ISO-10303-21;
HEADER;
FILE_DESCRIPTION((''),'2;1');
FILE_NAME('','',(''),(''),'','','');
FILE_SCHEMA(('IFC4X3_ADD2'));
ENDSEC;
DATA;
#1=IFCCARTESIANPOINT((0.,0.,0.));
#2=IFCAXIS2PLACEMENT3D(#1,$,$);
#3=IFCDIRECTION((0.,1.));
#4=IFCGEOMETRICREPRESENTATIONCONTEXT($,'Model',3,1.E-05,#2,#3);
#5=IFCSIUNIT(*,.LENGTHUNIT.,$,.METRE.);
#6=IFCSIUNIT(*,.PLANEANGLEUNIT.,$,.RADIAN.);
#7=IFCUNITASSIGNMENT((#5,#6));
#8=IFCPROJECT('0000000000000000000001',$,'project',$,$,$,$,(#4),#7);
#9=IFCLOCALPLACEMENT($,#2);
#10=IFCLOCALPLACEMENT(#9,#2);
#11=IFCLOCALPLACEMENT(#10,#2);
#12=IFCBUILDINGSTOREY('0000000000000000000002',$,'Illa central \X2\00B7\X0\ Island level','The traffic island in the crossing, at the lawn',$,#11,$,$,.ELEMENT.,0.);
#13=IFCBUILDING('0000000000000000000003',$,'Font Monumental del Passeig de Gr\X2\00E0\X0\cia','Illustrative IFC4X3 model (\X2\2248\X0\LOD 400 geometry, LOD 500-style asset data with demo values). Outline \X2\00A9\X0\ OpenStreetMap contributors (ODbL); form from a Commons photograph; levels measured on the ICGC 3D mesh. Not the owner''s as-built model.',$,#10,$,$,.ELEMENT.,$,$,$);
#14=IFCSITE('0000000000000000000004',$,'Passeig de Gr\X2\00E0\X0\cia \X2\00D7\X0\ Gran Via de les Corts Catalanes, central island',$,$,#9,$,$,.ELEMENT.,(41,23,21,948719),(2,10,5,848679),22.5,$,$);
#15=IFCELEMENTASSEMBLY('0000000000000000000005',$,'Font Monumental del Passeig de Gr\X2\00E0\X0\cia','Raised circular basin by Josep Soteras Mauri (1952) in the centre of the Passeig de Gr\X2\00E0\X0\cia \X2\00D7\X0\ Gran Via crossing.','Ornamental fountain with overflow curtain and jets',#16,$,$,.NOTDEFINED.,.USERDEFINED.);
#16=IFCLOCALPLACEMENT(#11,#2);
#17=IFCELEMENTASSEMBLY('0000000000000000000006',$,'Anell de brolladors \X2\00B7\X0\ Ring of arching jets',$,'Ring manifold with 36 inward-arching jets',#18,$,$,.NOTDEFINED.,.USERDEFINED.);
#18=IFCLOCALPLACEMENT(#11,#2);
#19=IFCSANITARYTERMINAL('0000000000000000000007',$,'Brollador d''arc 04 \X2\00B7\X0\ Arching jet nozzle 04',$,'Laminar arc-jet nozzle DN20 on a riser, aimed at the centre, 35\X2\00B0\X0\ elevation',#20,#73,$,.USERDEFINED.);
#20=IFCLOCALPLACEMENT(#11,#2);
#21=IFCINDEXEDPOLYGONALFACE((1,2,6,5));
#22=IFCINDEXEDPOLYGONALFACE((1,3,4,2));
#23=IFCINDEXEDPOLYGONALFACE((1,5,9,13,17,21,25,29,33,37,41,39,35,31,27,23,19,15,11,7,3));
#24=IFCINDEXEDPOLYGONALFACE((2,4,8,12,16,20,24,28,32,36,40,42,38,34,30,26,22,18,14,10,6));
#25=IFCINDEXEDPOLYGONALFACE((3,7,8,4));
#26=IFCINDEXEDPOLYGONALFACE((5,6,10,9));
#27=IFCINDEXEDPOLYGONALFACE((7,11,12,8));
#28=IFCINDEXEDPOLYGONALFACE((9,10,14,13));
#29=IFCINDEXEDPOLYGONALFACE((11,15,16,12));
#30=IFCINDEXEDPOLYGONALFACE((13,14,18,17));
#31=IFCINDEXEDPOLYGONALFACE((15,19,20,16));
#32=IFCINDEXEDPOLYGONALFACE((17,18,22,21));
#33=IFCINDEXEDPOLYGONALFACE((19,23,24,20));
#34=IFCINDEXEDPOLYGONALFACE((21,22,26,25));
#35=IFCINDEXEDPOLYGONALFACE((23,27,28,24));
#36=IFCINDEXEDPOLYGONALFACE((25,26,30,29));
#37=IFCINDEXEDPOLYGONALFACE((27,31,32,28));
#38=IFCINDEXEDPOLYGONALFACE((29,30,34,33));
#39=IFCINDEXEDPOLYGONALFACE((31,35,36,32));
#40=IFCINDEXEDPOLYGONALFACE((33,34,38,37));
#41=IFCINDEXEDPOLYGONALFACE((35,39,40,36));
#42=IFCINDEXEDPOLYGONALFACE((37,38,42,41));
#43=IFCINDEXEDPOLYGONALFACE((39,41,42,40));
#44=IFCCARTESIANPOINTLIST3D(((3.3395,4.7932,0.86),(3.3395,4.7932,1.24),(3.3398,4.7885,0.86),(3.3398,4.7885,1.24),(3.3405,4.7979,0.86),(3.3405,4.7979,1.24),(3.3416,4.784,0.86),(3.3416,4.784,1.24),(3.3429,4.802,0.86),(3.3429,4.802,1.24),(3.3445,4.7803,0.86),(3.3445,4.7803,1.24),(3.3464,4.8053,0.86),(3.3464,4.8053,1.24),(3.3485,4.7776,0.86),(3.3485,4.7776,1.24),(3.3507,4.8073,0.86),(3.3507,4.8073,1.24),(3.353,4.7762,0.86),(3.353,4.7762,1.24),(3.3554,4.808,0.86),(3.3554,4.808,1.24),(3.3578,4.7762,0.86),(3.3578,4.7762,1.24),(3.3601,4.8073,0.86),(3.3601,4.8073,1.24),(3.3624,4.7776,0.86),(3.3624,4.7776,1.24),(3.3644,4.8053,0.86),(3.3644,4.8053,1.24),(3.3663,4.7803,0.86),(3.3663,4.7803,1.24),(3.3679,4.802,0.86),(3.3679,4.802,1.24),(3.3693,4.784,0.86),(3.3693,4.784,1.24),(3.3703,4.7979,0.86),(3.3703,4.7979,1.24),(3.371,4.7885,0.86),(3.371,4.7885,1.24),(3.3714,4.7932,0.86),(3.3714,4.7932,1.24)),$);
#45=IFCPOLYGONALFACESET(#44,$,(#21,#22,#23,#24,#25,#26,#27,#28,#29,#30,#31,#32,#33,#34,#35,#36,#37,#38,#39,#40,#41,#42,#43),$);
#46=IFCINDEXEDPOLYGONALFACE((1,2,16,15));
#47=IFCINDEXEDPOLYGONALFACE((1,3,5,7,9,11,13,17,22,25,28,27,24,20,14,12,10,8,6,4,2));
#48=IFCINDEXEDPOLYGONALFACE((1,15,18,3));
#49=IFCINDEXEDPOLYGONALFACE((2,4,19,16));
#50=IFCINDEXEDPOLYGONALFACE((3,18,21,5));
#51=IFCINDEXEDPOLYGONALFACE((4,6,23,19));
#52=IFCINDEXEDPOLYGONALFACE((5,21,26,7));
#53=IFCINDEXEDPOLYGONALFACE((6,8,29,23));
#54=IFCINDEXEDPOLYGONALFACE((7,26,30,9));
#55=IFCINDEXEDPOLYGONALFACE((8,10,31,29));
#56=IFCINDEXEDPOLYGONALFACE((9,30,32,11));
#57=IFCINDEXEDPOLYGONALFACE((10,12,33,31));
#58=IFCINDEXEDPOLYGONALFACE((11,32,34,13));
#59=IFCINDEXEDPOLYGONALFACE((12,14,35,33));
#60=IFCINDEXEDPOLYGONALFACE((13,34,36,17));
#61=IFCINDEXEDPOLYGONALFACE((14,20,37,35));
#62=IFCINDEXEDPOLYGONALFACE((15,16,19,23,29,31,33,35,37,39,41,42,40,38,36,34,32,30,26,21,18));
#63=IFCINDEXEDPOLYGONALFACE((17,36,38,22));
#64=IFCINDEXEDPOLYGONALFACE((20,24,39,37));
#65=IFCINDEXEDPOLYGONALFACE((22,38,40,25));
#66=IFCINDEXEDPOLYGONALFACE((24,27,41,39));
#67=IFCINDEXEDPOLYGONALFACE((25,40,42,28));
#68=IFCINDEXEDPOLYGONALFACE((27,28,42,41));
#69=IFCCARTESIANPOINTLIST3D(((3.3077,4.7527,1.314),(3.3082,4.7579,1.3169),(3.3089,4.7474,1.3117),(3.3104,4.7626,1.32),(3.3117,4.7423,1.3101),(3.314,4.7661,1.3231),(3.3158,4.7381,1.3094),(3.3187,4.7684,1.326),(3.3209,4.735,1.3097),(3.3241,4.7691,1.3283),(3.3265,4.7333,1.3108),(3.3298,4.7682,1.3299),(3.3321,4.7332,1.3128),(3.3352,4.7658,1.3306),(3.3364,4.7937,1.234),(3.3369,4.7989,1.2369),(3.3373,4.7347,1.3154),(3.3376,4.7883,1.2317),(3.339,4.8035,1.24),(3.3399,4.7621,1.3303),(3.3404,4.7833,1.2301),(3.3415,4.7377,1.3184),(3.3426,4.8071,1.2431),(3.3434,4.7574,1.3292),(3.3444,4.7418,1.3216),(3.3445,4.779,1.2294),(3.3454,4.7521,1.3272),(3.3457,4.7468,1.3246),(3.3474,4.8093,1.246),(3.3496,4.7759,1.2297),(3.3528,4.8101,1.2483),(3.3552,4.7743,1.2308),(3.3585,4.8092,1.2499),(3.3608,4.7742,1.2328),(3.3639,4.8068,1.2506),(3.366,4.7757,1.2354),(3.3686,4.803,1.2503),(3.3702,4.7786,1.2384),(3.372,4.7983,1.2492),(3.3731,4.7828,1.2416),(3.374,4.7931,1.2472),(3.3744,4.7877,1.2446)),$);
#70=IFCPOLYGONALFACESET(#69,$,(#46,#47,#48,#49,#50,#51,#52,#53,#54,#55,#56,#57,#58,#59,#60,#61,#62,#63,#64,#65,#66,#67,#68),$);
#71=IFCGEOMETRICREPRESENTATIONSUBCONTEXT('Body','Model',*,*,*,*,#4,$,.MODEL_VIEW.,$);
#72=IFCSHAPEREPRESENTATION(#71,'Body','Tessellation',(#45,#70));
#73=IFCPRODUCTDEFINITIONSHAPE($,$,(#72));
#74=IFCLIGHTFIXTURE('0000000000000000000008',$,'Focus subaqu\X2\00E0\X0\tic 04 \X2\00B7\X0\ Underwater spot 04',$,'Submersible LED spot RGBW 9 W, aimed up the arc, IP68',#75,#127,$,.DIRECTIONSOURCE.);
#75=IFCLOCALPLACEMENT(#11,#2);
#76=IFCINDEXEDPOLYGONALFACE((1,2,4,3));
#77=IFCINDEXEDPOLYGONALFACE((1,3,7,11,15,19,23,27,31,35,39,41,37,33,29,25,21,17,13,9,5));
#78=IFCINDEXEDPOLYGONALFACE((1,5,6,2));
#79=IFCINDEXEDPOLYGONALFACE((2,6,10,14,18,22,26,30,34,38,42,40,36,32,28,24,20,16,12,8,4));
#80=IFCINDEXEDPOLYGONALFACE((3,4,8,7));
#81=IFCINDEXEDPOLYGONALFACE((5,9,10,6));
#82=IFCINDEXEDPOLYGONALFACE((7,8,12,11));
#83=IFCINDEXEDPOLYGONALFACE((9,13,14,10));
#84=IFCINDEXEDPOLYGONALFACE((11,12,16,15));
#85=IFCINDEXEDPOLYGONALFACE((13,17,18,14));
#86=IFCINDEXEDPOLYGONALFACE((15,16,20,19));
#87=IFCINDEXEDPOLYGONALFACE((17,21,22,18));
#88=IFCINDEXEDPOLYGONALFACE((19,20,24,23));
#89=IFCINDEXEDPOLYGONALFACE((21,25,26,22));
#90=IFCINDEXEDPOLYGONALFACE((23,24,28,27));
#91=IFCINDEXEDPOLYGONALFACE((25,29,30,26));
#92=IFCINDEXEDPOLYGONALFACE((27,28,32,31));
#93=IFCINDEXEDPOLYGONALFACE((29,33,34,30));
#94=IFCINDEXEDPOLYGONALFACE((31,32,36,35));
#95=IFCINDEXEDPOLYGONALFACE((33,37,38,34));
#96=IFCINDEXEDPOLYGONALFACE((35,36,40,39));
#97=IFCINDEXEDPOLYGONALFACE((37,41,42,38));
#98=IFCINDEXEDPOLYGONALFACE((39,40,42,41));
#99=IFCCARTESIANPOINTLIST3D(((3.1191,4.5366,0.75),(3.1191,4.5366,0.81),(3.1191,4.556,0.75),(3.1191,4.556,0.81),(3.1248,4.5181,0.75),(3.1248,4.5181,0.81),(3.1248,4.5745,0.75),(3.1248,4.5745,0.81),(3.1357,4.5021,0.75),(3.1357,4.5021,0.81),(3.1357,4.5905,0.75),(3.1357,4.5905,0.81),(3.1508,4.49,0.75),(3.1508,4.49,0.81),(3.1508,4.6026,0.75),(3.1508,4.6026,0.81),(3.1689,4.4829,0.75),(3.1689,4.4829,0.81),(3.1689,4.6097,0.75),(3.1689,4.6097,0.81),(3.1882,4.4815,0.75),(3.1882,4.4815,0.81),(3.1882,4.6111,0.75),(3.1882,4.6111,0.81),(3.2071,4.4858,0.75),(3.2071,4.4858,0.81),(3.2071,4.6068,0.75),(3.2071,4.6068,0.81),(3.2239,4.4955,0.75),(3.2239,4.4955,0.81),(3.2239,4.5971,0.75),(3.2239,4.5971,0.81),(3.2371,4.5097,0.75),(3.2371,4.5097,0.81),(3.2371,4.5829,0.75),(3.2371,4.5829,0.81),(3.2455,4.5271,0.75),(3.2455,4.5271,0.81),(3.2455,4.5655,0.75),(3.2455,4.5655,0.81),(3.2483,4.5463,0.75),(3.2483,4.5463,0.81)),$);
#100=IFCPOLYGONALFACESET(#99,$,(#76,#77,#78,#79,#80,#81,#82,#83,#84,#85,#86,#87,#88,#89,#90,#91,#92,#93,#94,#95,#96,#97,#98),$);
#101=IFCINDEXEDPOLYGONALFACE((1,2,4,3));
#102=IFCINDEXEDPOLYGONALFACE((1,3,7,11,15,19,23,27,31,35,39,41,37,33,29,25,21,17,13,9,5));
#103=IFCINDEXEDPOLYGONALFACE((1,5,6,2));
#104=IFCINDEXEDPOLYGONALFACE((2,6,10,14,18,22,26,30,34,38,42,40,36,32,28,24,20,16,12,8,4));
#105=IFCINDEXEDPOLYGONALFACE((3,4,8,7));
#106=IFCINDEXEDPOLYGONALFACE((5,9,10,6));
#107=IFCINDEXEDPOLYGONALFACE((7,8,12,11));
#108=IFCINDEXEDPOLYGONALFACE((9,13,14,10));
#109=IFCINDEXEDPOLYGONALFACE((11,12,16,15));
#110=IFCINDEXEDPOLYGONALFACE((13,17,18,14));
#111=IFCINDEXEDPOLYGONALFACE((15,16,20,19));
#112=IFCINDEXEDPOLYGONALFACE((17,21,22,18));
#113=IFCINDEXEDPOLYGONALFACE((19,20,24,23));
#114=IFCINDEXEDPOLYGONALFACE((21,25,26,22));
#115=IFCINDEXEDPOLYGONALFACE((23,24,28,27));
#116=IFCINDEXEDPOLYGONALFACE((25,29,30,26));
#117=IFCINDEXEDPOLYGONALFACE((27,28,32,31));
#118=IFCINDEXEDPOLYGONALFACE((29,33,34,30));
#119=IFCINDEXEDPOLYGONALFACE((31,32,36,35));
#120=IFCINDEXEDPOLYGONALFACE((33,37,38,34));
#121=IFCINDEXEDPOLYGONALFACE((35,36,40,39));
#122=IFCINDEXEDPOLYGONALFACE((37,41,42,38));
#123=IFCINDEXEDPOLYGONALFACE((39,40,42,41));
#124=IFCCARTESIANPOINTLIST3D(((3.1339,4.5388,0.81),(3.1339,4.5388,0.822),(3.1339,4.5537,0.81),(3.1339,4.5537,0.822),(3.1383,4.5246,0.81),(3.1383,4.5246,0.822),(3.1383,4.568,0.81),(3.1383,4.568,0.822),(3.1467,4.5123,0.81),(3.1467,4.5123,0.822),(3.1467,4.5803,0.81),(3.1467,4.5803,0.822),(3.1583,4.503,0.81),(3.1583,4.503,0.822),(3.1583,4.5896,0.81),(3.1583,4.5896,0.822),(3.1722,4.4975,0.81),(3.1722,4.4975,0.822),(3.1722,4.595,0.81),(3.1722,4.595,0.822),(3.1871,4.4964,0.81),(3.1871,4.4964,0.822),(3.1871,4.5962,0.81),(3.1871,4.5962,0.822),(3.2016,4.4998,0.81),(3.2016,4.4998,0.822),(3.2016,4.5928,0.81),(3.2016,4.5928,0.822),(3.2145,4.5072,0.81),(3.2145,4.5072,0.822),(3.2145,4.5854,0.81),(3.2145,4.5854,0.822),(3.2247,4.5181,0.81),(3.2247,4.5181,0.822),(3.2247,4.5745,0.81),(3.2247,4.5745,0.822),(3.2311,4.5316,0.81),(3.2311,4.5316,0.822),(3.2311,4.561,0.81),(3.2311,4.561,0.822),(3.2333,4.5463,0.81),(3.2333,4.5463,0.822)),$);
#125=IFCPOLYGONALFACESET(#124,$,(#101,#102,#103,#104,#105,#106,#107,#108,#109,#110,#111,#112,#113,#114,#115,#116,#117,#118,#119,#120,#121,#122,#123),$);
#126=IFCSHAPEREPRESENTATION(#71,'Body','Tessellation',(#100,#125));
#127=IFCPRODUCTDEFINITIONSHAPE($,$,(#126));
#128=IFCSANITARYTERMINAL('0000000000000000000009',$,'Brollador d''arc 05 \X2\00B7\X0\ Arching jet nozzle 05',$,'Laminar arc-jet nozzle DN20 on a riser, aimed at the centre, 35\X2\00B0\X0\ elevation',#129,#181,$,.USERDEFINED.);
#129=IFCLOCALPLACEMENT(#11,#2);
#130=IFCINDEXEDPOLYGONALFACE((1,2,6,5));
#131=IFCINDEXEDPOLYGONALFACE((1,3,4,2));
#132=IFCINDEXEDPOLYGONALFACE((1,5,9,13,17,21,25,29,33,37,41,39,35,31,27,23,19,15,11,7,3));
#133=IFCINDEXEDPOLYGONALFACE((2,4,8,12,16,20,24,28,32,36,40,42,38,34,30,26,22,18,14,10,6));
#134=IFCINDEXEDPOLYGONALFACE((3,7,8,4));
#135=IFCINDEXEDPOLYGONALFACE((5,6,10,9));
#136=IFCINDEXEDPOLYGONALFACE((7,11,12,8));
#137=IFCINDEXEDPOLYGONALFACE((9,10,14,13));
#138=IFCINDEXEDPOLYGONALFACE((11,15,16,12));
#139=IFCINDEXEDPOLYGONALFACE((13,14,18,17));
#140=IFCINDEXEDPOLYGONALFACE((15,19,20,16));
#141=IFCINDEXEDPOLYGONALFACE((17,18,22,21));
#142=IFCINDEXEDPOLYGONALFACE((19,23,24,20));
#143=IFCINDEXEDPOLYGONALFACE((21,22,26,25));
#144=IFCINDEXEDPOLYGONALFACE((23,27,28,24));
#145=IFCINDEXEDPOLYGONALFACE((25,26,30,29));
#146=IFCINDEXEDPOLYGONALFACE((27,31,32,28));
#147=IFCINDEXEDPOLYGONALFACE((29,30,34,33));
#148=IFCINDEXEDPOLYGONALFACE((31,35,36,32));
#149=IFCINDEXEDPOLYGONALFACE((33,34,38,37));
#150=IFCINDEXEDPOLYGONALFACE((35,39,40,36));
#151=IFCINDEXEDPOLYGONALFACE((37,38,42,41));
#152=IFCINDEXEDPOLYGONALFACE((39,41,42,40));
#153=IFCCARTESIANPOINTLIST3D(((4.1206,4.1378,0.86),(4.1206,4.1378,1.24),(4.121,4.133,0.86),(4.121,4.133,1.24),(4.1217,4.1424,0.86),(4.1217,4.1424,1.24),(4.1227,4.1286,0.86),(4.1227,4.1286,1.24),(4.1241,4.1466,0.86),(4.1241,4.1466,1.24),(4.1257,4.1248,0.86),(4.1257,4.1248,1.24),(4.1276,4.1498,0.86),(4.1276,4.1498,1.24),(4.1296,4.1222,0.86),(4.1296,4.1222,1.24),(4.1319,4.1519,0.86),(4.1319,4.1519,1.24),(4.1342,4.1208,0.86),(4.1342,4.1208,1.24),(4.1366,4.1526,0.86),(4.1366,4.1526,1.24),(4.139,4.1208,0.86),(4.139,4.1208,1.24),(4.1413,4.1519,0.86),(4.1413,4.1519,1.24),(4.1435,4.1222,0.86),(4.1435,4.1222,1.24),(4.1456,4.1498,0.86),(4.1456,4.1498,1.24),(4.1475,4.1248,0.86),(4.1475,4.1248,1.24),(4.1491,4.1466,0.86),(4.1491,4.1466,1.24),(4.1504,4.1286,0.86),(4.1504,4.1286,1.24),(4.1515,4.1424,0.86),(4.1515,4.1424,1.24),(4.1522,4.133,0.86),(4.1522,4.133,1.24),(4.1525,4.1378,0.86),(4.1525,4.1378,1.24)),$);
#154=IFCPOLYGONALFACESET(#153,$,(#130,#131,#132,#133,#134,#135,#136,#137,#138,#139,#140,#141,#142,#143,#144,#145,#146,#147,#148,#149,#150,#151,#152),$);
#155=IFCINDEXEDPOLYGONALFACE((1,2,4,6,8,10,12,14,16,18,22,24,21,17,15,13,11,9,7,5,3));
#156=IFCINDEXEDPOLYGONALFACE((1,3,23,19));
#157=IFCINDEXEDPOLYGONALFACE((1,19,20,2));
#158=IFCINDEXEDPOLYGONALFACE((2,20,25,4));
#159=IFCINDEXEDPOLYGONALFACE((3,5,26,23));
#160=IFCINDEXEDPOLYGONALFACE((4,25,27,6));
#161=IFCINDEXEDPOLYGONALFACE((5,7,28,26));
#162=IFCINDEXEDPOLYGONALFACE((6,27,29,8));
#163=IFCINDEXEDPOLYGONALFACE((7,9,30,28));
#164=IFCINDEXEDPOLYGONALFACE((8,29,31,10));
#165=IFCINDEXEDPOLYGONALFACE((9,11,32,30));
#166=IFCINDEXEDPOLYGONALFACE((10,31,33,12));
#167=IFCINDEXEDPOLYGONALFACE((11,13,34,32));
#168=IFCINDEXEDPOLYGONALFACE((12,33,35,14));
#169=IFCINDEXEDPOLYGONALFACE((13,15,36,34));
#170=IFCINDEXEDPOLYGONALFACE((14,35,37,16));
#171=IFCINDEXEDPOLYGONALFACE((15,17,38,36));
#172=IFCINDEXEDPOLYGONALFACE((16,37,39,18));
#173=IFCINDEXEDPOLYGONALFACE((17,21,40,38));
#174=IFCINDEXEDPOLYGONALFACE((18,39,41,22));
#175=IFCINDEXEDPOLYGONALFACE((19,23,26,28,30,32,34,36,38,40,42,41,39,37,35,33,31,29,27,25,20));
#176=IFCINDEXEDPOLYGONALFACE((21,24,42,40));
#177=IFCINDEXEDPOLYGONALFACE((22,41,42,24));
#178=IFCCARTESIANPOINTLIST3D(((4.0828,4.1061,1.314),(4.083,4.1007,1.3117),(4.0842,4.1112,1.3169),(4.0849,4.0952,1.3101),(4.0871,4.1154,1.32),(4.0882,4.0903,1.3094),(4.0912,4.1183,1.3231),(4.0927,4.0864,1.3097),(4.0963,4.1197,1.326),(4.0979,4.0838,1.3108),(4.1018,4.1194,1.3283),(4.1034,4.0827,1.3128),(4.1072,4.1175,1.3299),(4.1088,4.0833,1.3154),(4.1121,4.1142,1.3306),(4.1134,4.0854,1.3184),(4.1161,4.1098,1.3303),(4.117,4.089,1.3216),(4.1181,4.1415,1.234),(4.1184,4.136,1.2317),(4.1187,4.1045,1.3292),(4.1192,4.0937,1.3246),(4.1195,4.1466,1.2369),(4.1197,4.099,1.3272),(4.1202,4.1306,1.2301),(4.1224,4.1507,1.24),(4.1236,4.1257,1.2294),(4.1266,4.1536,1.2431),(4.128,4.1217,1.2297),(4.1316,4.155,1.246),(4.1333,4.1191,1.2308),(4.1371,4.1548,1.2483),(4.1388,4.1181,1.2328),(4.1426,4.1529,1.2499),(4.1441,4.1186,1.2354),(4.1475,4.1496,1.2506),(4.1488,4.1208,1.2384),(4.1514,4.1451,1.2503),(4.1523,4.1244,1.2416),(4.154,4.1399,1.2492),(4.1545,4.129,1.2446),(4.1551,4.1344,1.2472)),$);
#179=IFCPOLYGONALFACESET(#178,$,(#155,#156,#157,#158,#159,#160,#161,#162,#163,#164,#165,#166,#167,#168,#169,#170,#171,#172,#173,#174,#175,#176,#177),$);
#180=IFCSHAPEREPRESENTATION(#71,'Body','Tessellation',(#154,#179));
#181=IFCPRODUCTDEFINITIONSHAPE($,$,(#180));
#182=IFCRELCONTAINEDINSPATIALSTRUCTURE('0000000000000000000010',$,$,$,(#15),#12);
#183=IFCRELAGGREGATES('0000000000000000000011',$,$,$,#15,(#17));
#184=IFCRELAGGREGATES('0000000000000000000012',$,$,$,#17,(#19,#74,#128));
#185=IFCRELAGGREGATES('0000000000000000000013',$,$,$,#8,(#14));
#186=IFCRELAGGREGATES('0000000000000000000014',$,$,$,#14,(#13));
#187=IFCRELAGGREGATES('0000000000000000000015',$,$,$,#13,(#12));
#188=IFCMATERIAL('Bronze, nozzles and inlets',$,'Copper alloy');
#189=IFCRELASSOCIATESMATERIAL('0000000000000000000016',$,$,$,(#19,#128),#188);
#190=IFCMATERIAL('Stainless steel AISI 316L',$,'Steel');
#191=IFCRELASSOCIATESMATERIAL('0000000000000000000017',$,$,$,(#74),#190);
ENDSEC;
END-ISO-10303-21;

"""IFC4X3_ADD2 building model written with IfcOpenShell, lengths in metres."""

from ifc_helpers import new_model, si_unit, direction, frame, origin, origin_2d_with_axis, place, context, subcontext, project, spatial, circle, extrude, material, element, aggregate, save


model = new_model("IFC4X3_ADD2")

# Units and contexts
model_context = context("Model", 3, precision=1e-05, world=origin(), true_north=direction((0.0, 1.0)))
body_context = subcontext(model_context, "Body", "Model", "MODEL_VIEW")
ifc_project = project(units=[si_unit("LENGTHUNIT", "METRE"), si_unit("PLANEANGLEUNIT", "RADIAN")], contexts=[model_context])

# Site, building, storey
site_placement = place(None, origin())
site = spatial("IfcSite", under=ifc_project, at=site_placement, Name="Passeig de Gràcia × Gran Via de les Corts Catalanes, central island", CompositionType="ELEMENT", RefLatitude=(41, 23, 21, 948719), RefLongitude=(2, 10, 5, 848679), RefElevation=22.5)
building_placement = place(site_placement, origin())
building = spatial("IfcBuilding", under=site, at=building_placement, Name="Font Monumental del Passeig de Gràcia", Description="Illustrative IFC4X3 model (≈LOD 400 geometry, LOD 500-style asset data with demo values). Outline © OpenStreetMap contributors (ODbL); form from a Commons photograph; levels measured on the ICGC 3D mesh. Not the owner's as-built model.", CompositionType="ELEMENT")
storey_placement = place(building_placement, origin())
storey = spatial("IfcBuildingStorey", under=building, at=storey_placement, Name="Illa central · Island level", Description="The traffic island in the crossing, at the lawn", CompositionType="ELEMENT", Elevation=0.0)

# Element assemblies, sanitary terminals, light fixture
assembly_1_placement = place(building_placement, origin())
assembly_1 = element("IfcElementAssembly", 1, at=assembly_1_placement, inside=storey, Name="Font Monumental del Passeig de Gràcia", Description="Raised circular basin by Josep Soteras Mauri (1952) in the centre of the Passeig de Gràcia × Gran Via crossing.", ObjectType="Ornamental fountain with overflow curtain and jets", AssemblyPlace="NOTDEFINED", PredefinedType="USERDEFINED")
ifc_material_1 = material(Name="Bronze, nozzles and inlets", Category="Copper alloy")
ifc_material_2 = material(Name="Stainless steel AISI 316L", Category="Steel")
assembly_2_placement = place(building_placement, origin())
assembly_2 = element("IfcElementAssembly", 2, at=assembly_2_placement, Name="Anell de brolladors · Ring of arching jets", ObjectType="Ring manifold with 36 inward-arching jets", AssemblyPlace="NOTDEFINED", PredefinedType="USERDEFINED")
sanitary_terminal_1_placement = place(building_placement, origin())
sanitary_terminal_1 = element("IfcSanitaryTerminal", 3, at=sanitary_terminal_1_placement, material=ifc_material_1, Name="Brollador d'arc 04 · Arching jet nozzle 04", ObjectType="Laminar arc-jet nozzle DN20 on a riser, aimed at the centre, 35° elevation", PredefinedType="USERDEFINED", context=body_context, shape_type="SweptSolid", body=[
    extrude(circle(Radius=0.016, at=origin_2d_with_axis()), frame((3.3554, 4.792, 0.86), z_axis=(0.0, 0.0, 1.0), x_axis=(0.0, 1.0, 0.0)), (0.0, 0.0, 1.0), 0.38),
    extrude(circle(Radius=0.02, at=origin_2d_with_axis()), frame((3.3554, 4.792, 1.24), z_axis=(-0.303995, -0.43415, 0.847998), x_axis=(-0.819152, 0.573576, 0.0)), (0.0, 0.0, 1.0), 0.0943),
])
light_fixture_1_placement = place(building_placement, origin())
light_fixture_1 = element("IfcLightFixture", 4, at=light_fixture_1_placement, material=ifc_material_2, Name="Focus subaquàtic 04 · Underwater spot 04", ObjectType="Submersible LED spot RGBW 9 W, aimed up the arc, IP68", PredefinedType="DIRECTIONSOURCE", context=body_context, shape_type="SweptSolid", body=[
    extrude(circle(Radius=0.065, at=origin_2d_with_axis()), frame((3.1833, 4.5463, 0.75)), (0.0, 0.0, 1.0), 0.06),
    extrude(circle(Radius=0.05, at=origin_2d_with_axis()), frame((3.1833, 4.5463, 0.81)), (0.0, 0.0, 1.0), 0.012),
])
sanitary_terminal_2_placement = place(building_placement, origin())
sanitary_terminal_2 = element("IfcSanitaryTerminal", 5, at=sanitary_terminal_2_placement, material=ifc_material_1, Name="Brollador d'arc 05 · Arching jet nozzle 05", ObjectType="Laminar arc-jet nozzle DN20 on a riser, aimed at the centre, 35° elevation", PredefinedType="USERDEFINED", context=body_context, shape_type="SweptSolid", body=[
    extrude(circle(Radius=0.016, at=origin_2d_with_axis()), frame((4.1366, 4.1366, 0.86), z_axis=(0.0, 0.0, 1.0), x_axis=(0.0, 1.0, 0.0)), (0.0, 0.0, 1.0), 0.38),
    extrude(circle(Radius=0.02, at=origin_2d_with_axis()), frame((4.1366, 4.1366, 1.24), z_axis=(-0.374766, -0.374766, 0.847998), x_axis=(-0.707107, 0.707107, 0.0)), (0.0, 0.0, 1.0), 0.0943),
])
aggregate(assembly_1, [assembly_2])
aggregate(assembly_2, [sanitary_terminal_1, light_fixture_1, sanitary_terminal_2])

save(model, "model.ifc")
